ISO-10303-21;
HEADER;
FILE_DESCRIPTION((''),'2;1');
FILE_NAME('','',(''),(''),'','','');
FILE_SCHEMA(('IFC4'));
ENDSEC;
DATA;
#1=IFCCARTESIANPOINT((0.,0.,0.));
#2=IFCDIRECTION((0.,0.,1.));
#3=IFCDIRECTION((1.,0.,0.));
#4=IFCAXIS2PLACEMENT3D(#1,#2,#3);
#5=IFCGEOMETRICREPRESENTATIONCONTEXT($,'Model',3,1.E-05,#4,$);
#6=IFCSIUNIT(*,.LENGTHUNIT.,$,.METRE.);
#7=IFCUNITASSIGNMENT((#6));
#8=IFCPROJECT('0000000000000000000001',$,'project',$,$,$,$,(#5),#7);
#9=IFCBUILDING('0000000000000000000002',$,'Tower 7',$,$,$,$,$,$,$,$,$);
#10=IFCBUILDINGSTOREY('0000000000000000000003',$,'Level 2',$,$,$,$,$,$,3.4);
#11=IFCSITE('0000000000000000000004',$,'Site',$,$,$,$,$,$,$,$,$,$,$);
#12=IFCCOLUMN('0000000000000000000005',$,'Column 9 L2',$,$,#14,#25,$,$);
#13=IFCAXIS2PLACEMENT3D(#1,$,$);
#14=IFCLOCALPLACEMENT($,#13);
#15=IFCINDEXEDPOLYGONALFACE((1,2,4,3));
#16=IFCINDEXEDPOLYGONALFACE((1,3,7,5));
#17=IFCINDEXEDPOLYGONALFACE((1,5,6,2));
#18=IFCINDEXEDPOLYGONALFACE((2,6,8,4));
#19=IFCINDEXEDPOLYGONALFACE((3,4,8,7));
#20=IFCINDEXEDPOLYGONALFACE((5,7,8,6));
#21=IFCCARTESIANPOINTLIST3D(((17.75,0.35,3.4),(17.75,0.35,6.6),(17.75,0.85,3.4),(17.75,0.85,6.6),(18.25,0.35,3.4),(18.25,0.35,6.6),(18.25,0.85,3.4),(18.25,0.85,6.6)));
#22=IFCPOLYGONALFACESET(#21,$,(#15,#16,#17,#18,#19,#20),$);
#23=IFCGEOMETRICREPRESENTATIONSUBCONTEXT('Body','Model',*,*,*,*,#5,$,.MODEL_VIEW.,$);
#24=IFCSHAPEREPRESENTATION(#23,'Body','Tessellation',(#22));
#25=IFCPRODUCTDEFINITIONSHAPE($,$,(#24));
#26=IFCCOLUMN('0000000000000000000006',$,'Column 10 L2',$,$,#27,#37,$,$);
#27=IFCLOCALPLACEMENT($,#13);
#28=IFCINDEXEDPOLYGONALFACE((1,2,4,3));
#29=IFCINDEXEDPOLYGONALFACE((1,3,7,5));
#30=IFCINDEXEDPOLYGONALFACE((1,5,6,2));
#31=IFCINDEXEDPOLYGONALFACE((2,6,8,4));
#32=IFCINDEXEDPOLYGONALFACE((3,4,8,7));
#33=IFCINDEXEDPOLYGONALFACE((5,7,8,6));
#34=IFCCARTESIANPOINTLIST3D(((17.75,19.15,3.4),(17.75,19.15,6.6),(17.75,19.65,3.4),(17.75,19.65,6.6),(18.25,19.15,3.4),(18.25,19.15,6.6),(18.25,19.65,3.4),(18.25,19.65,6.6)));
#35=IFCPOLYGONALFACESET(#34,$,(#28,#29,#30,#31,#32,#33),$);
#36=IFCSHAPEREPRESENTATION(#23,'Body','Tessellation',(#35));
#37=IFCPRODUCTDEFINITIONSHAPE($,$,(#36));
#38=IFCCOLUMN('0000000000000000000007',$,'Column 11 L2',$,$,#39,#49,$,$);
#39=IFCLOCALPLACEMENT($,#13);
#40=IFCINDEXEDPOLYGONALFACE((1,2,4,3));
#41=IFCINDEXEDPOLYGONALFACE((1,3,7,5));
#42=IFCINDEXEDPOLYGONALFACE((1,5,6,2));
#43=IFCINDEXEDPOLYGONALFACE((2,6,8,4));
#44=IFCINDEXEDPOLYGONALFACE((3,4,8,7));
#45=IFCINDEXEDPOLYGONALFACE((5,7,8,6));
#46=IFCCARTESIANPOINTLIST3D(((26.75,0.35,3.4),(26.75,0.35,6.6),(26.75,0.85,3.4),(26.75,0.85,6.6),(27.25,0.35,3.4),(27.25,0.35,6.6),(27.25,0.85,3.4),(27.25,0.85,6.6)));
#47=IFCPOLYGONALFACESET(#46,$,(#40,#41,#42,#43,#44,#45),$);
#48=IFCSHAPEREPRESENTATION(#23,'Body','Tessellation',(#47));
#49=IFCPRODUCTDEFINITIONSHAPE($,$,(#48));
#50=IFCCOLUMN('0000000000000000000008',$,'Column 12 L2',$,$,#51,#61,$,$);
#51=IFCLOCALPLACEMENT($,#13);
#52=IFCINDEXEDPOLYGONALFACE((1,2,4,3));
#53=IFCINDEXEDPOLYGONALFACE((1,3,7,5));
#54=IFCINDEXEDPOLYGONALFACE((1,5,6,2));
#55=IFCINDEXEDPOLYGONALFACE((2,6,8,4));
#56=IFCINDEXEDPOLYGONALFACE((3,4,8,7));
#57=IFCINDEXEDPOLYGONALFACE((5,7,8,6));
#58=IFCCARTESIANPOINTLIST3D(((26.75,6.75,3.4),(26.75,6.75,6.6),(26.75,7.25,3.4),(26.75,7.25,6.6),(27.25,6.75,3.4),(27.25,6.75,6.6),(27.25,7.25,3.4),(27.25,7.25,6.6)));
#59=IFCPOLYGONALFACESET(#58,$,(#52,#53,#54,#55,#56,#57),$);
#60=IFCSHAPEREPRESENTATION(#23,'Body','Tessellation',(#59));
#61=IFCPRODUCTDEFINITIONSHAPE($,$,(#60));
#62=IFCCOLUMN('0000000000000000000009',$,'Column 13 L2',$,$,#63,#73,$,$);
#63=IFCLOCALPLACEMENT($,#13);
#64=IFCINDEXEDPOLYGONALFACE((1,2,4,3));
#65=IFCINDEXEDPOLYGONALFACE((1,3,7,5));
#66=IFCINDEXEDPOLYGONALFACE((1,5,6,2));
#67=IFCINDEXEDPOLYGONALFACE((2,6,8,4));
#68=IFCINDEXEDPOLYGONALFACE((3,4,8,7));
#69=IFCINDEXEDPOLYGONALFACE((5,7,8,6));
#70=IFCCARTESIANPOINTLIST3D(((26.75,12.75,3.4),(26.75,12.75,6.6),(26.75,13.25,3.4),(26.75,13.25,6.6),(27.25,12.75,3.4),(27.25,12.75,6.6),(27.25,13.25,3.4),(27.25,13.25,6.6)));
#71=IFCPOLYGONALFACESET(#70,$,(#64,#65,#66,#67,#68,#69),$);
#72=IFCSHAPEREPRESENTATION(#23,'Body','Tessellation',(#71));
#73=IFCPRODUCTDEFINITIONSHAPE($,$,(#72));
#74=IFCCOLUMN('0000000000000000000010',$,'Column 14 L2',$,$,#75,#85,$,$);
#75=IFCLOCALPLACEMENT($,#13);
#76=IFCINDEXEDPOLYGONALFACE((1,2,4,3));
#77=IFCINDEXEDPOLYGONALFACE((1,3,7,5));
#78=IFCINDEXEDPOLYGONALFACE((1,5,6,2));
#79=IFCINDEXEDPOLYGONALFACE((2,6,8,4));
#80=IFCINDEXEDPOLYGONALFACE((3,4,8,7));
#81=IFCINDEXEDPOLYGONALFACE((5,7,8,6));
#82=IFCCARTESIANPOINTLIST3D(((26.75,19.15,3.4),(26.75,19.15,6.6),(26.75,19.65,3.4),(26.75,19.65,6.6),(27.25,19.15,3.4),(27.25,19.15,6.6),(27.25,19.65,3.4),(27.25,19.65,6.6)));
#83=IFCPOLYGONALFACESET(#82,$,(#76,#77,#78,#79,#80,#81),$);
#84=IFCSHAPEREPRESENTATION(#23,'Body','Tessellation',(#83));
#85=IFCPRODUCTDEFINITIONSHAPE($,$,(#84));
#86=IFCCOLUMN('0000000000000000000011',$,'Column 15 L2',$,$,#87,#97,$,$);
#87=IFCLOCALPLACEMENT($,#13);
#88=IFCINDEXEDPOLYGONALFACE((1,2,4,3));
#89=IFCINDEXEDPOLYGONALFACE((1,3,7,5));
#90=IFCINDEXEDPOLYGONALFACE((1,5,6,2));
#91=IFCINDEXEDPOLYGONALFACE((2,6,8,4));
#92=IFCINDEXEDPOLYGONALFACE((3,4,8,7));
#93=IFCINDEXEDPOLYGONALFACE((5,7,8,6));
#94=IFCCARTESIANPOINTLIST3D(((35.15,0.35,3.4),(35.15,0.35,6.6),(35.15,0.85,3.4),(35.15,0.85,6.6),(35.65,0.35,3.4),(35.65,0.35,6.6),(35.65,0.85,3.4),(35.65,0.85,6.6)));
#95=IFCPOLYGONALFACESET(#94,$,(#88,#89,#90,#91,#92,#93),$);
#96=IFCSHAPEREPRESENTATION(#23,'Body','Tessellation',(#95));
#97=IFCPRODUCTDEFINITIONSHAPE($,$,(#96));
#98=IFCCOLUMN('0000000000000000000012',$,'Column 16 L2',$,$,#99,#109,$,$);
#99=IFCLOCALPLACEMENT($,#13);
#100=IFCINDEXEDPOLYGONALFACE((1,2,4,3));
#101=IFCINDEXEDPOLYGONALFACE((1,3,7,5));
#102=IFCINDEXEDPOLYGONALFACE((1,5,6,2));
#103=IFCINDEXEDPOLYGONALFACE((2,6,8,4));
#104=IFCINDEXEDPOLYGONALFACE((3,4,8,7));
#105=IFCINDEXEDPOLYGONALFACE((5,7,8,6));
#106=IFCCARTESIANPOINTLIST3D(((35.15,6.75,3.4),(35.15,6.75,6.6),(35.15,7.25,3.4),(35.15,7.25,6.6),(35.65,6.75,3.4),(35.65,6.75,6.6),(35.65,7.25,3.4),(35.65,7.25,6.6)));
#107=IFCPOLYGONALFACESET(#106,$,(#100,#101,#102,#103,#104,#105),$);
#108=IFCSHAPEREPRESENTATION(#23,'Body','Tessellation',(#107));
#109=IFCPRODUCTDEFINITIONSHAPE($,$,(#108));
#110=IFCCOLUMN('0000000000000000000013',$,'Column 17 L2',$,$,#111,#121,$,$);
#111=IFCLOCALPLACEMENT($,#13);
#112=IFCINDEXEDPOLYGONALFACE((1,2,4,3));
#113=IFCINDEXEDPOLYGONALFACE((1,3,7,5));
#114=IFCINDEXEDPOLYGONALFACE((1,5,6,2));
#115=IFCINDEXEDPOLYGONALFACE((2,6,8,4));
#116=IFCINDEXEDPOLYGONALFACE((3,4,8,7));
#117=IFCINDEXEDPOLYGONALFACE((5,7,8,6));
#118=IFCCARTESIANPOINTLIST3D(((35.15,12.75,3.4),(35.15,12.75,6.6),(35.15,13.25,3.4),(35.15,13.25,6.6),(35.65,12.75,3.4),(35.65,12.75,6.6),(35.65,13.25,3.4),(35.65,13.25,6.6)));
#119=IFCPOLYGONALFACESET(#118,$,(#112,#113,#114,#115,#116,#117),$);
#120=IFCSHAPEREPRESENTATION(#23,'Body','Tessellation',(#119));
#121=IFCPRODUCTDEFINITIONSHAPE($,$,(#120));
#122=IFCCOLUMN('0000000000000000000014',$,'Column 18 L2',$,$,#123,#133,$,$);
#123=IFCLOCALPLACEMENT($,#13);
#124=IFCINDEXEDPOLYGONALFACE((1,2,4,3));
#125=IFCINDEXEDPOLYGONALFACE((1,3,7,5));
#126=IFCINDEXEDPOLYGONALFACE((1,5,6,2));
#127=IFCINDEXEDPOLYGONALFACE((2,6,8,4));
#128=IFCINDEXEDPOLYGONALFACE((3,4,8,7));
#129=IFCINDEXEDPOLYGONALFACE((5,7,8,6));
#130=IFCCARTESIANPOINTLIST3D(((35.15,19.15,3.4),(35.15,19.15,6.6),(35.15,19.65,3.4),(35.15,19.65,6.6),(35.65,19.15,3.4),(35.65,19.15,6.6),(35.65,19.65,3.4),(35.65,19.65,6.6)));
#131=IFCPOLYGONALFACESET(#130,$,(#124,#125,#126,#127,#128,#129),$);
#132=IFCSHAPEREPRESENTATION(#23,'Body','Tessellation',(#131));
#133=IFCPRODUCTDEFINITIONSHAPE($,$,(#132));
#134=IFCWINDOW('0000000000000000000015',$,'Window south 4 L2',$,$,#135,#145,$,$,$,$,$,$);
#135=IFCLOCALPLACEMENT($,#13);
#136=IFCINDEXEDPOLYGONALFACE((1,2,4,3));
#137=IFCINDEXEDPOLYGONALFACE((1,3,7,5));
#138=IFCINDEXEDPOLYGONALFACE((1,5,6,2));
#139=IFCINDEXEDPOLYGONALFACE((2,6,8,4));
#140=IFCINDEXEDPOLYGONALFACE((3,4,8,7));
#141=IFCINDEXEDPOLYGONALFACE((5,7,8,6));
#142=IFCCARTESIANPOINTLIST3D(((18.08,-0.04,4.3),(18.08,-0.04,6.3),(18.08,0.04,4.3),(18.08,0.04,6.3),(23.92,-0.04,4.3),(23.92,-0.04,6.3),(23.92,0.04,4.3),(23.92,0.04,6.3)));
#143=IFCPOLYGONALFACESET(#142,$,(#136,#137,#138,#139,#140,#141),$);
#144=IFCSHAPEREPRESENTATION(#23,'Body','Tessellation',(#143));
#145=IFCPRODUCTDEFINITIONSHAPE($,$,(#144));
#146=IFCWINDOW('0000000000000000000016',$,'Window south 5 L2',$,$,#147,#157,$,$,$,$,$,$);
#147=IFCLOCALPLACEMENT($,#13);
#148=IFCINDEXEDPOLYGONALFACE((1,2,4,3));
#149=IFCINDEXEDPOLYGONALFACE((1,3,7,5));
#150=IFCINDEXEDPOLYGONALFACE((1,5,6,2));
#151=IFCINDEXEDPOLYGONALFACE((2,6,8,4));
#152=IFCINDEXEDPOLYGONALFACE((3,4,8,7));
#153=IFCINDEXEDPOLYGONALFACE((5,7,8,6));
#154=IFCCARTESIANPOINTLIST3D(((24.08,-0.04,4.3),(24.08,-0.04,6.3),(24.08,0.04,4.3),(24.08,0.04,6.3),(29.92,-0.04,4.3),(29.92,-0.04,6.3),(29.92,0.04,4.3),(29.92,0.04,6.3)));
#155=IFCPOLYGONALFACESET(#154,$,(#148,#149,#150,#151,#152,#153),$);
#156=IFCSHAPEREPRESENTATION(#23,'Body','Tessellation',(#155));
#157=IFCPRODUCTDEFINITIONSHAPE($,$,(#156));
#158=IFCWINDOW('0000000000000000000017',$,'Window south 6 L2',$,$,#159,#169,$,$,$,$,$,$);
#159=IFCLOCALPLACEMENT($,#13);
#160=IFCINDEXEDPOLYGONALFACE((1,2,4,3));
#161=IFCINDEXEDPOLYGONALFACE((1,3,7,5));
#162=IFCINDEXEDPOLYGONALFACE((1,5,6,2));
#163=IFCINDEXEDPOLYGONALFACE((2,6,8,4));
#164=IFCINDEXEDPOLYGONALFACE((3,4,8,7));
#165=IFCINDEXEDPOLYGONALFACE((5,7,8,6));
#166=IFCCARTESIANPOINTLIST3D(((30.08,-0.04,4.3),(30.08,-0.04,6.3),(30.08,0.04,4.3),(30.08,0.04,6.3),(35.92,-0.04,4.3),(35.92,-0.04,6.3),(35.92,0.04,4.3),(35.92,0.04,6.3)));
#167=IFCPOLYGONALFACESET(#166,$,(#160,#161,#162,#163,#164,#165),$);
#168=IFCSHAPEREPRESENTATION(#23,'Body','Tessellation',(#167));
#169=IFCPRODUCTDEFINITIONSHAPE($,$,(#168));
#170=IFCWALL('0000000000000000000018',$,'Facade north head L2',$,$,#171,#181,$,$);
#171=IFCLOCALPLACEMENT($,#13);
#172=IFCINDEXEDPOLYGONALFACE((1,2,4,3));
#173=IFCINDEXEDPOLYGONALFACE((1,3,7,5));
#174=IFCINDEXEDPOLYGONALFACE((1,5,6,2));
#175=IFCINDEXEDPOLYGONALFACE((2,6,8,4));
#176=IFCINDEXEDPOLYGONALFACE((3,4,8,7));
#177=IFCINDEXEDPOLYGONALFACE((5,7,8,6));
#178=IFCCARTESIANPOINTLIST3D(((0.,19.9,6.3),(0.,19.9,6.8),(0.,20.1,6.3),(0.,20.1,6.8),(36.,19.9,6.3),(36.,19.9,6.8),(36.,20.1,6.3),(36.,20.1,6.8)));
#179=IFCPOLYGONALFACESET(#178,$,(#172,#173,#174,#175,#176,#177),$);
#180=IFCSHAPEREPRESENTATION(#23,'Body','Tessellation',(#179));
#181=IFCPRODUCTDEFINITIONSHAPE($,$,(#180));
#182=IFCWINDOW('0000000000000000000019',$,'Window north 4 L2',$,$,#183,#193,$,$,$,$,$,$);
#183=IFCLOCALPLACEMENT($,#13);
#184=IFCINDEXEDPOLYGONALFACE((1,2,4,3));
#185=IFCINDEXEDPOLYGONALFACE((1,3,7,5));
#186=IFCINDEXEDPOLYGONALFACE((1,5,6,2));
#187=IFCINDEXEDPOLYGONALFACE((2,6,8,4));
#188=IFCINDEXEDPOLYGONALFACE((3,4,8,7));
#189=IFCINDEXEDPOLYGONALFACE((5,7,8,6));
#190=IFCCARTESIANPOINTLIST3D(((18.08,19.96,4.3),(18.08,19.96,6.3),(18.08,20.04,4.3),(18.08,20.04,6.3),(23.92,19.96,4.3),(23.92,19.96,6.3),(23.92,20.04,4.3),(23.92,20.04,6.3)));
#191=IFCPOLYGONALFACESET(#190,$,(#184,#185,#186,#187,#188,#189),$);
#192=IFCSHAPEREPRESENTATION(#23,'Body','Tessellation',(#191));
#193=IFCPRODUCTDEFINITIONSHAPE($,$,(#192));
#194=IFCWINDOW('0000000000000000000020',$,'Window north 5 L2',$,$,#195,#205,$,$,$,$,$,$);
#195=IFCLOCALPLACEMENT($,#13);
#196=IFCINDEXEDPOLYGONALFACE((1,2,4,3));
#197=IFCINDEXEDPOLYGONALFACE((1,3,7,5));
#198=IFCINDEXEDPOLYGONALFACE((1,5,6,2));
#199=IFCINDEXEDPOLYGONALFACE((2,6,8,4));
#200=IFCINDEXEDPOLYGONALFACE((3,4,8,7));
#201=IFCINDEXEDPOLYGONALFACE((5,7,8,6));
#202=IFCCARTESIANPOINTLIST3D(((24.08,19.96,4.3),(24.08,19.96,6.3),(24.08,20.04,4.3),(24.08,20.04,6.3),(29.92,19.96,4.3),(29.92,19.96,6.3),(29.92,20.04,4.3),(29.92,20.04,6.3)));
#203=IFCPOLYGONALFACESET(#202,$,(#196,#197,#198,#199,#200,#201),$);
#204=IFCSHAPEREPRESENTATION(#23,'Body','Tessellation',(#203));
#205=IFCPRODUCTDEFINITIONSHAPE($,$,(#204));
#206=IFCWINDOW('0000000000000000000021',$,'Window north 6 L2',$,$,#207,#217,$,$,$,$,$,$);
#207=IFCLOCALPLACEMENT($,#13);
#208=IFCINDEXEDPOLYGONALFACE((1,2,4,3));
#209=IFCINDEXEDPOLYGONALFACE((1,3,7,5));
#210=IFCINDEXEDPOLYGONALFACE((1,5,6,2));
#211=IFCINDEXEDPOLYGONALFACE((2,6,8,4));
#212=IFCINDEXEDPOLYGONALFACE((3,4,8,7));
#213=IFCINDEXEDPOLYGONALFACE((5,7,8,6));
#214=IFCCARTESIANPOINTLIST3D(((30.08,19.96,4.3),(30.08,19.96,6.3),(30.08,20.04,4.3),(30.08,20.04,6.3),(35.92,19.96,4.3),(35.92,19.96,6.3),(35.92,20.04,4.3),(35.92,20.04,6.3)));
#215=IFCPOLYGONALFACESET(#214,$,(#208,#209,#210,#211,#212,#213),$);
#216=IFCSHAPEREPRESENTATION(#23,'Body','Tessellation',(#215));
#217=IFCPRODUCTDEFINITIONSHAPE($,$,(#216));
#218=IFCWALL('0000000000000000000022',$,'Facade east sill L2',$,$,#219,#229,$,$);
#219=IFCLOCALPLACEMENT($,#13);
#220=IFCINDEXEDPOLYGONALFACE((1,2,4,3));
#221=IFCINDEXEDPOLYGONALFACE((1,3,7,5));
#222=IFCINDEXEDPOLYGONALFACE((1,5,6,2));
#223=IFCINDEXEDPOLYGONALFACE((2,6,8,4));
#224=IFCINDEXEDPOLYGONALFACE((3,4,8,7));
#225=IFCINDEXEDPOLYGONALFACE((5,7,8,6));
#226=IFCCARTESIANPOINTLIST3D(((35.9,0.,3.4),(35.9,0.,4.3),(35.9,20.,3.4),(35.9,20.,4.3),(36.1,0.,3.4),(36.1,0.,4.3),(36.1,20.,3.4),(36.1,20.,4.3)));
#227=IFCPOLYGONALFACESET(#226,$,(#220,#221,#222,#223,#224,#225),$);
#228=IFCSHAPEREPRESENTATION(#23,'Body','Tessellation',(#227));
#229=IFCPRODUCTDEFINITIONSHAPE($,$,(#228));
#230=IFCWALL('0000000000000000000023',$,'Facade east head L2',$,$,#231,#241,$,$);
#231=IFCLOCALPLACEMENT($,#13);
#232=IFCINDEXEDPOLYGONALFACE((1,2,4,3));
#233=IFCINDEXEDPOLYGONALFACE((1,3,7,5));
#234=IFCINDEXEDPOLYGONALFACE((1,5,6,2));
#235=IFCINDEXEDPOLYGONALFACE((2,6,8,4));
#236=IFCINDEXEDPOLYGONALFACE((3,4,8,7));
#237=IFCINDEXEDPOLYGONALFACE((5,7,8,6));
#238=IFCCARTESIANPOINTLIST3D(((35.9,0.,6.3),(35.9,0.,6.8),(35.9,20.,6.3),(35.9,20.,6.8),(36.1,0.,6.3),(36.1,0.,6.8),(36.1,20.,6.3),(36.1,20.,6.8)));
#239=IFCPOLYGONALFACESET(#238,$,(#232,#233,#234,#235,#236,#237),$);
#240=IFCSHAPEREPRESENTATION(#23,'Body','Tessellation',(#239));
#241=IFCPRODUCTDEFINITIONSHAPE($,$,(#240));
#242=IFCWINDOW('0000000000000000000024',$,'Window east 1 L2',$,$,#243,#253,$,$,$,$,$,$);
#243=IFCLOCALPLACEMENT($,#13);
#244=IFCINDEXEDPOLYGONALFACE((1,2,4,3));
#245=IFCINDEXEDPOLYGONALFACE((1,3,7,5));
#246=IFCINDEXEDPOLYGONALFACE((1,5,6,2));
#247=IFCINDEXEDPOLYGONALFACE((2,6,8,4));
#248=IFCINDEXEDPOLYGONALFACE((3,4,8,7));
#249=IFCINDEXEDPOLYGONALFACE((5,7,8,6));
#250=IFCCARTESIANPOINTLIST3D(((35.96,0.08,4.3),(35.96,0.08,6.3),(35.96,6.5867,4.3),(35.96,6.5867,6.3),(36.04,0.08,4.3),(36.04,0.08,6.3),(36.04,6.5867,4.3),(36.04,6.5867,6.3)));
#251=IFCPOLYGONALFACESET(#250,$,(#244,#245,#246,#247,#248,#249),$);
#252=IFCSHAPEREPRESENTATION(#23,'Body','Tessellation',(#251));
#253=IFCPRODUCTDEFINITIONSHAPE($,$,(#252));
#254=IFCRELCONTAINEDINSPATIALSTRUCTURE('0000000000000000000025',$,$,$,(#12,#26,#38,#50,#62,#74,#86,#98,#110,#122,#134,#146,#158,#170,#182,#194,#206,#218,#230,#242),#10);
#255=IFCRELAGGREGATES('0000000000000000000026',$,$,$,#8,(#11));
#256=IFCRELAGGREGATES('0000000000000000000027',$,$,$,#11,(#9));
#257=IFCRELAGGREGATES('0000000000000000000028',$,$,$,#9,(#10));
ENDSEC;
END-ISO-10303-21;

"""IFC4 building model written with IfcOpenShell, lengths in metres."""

from ifc_helpers import new_model, si_unit, frame, origin, origin_with_axes, origin_2d, place, context, subcontext, project, spatial, rectangle, extrude, element, save


model = new_model("IFC4")

# Units and contexts
model_context = context("Model", 3, precision=1e-05, world=origin_with_axes())
body_context = subcontext(model_context, "Body", "Model", "MODEL_VIEW")
ifc_project = project(units=[si_unit("LENGTHUNIT", "METRE")], contexts=[model_context])

# Site, building, storey
site = spatial("IfcSite", under=ifc_project, Name="Site")
building = spatial("IfcBuilding", under=site, Name="Tower 7")
storey = spatial("IfcBuildingStorey", under=building, Name="Level 2", Elevation=3.4)

# Columns
for number, where, z_axis, x_axis, name in (
    (1, (18.0, 0.6, 3.4), (0.0, 0.0, 1.0), (1.0, 0.0, 0.0), "Column 9 L2"),
    (2, (18.0, 19.4, 3.4), (0.0, 0.0, 1.0), (1.0, 0.0, 0.0), "Column 10 L2"),
    (3, (27.0, 0.6, 3.4), (0.0, 0.0, 1.0), (1.0, 0.0, 0.0), "Column 11 L2"),
    (4, (27.0, 7.0, 3.4), (0.0, 0.0, 1.0), (1.0, 0.0, 0.0), "Column 12 L2"),
    (5, (27.0, 13.0, 3.4), (0.0, 0.0, 1.0), (1.0, 0.0, 0.0), "Column 13 L2"),
    (6, (27.0, 19.4, 3.4), (0.0, 0.0, 1.0), (1.0, 0.0, 0.0), "Column 14 L2"),
    (7, (35.4, 0.6, 3.4), (0.0, 0.0, 1.0), (1.0, 0.0, 0.0), "Column 15 L2"),
    (8, (35.4, 7.0, 3.4), (0.0, 0.0, 1.0), (1.0, 0.0, 0.0), "Column 16 L2"),
    (9, (35.4, 13.0, 3.4), (0.0, 0.0, 1.0), (1.0, 0.0, 0.0), "Column 17 L2"),
    (10, (35.4, 19.4, 3.4), (0.0, 0.0, 1.0), (1.0, 0.0, 0.0), "Column 18 L2"),
):
    element("IfcColumn", number, at=place(None, frame(where, z_axis=z_axis, x_axis=x_axis)), inside=storey, Name=name, context=body_context, shape_type="SweptSolid", body=[
        extrude(rectangle(XDim=0.5, YDim=0.5, at=origin_2d()), origin(), (0.0, 0.0, 1.0), 3.2),
    ])

# Windows
for number, where, z_axis, x_axis, name in (
    (11, (21.0, 0.0, 4.3), (0.0, 0.0, 1.0), (1.0, 0.0, 0.0), "Window south 4 L2"),
    (12, (27.0, 0.0, 4.3), (0.0, 0.0, 1.0), (1.0, 0.0, 0.0), "Window south 5 L2"),
    (13, (33.0, 0.0, 4.3), (0.0, 0.0, 1.0), (1.0, 0.0, 0.0), "Window south 6 L2"),
):
    element("IfcWindow", number, at=place(None, frame(where, z_axis=z_axis, x_axis=x_axis)), inside=storey, Name=name, context=body_context, shape_type="SweptSolid", body=[
        extrude(rectangle(XDim=5.84, YDim=0.08, at=origin_2d()), origin(), (0.0, 0.0, 1.0), 2.0),
    ])

# Wall
wall_1_placement = place(None, frame((18.0, 20.0, 6.3), z_axis=(0.0, 0.0, 1.0), x_axis=(1.0, 0.0, 0.0)))
element("IfcWall", 14, at=wall_1_placement, inside=storey, Name="Facade north head L2", context=body_context, shape_type="SweptSolid", body=[
    extrude(rectangle(XDim=36.0, YDim=0.2, at=origin_2d()), origin(), (0.0, 0.0, 1.0), 0.5),
])

# Windows
for number, where, z_axis, x_axis, name in (
    (15, (21.0, 20.0, 4.3), (0.0, 0.0, 1.0), (1.0, 0.0, 0.0), "Window north 4 L2"),
    (16, (27.0, 20.0, 4.3), (0.0, 0.0, 1.0), (1.0, 0.0, 0.0), "Window north 5 L2"),
    (17, (33.0, 20.0, 4.3), (0.0, 0.0, 1.0), (1.0, 0.0, 0.0), "Window north 6 L2"),
):
    element("IfcWindow", number, at=place(None, frame(where, z_axis=z_axis, x_axis=x_axis)), inside=storey, Name=name, context=body_context, shape_type="SweptSolid", body=[
        extrude(rectangle(XDim=5.84, YDim=0.08, at=origin_2d()), origin(), (0.0, 0.0, 1.0), 2.0),
    ])

# Walls
wall_2_placement = place(None, frame((36.0, 10.0, 3.4), z_axis=(0.0, 0.0, 1.0), x_axis=(1.0, 0.0, 0.0)))
element("IfcWall", 18, at=wall_2_placement, inside=storey, Name="Facade east sill L2", context=body_context, shape_type="SweptSolid", body=[
    extrude(rectangle(XDim=0.2, YDim=20.0, at=origin_2d()), origin(), (0.0, 0.0, 1.0), 0.9),
])
wall_3_placement = place(None, frame((36.0, 10.0, 6.3), z_axis=(0.0, 0.0, 1.0), x_axis=(1.0, 0.0, 0.0)))
element("IfcWall", 19, at=wall_3_placement, inside=storey, Name="Facade east head L2", context=body_context, shape_type="SweptSolid", body=[
    extrude(rectangle(XDim=0.2, YDim=20.0, at=origin_2d()), origin(), (0.0, 0.0, 1.0), 0.5),
])

# Window
for number, where, z_axis, x_axis, name in (
    (20, (36.0, 3.3333, 4.3), (0.0, 0.0, 1.0), (1.0, 0.0, 0.0), "Window east 1 L2"),
):
    element("IfcWindow", number, at=place(None, frame(where, z_axis=z_axis, x_axis=x_axis)), inside=storey, Name=name, context=body_context, shape_type="SweptSolid", body=[
        extrude(rectangle(XDim=0.08, YDim=6.5067, at=origin_2d()), origin(), (0.0, 0.0, 1.0), 2.0),
    ])

save(model, "model.ifc")
